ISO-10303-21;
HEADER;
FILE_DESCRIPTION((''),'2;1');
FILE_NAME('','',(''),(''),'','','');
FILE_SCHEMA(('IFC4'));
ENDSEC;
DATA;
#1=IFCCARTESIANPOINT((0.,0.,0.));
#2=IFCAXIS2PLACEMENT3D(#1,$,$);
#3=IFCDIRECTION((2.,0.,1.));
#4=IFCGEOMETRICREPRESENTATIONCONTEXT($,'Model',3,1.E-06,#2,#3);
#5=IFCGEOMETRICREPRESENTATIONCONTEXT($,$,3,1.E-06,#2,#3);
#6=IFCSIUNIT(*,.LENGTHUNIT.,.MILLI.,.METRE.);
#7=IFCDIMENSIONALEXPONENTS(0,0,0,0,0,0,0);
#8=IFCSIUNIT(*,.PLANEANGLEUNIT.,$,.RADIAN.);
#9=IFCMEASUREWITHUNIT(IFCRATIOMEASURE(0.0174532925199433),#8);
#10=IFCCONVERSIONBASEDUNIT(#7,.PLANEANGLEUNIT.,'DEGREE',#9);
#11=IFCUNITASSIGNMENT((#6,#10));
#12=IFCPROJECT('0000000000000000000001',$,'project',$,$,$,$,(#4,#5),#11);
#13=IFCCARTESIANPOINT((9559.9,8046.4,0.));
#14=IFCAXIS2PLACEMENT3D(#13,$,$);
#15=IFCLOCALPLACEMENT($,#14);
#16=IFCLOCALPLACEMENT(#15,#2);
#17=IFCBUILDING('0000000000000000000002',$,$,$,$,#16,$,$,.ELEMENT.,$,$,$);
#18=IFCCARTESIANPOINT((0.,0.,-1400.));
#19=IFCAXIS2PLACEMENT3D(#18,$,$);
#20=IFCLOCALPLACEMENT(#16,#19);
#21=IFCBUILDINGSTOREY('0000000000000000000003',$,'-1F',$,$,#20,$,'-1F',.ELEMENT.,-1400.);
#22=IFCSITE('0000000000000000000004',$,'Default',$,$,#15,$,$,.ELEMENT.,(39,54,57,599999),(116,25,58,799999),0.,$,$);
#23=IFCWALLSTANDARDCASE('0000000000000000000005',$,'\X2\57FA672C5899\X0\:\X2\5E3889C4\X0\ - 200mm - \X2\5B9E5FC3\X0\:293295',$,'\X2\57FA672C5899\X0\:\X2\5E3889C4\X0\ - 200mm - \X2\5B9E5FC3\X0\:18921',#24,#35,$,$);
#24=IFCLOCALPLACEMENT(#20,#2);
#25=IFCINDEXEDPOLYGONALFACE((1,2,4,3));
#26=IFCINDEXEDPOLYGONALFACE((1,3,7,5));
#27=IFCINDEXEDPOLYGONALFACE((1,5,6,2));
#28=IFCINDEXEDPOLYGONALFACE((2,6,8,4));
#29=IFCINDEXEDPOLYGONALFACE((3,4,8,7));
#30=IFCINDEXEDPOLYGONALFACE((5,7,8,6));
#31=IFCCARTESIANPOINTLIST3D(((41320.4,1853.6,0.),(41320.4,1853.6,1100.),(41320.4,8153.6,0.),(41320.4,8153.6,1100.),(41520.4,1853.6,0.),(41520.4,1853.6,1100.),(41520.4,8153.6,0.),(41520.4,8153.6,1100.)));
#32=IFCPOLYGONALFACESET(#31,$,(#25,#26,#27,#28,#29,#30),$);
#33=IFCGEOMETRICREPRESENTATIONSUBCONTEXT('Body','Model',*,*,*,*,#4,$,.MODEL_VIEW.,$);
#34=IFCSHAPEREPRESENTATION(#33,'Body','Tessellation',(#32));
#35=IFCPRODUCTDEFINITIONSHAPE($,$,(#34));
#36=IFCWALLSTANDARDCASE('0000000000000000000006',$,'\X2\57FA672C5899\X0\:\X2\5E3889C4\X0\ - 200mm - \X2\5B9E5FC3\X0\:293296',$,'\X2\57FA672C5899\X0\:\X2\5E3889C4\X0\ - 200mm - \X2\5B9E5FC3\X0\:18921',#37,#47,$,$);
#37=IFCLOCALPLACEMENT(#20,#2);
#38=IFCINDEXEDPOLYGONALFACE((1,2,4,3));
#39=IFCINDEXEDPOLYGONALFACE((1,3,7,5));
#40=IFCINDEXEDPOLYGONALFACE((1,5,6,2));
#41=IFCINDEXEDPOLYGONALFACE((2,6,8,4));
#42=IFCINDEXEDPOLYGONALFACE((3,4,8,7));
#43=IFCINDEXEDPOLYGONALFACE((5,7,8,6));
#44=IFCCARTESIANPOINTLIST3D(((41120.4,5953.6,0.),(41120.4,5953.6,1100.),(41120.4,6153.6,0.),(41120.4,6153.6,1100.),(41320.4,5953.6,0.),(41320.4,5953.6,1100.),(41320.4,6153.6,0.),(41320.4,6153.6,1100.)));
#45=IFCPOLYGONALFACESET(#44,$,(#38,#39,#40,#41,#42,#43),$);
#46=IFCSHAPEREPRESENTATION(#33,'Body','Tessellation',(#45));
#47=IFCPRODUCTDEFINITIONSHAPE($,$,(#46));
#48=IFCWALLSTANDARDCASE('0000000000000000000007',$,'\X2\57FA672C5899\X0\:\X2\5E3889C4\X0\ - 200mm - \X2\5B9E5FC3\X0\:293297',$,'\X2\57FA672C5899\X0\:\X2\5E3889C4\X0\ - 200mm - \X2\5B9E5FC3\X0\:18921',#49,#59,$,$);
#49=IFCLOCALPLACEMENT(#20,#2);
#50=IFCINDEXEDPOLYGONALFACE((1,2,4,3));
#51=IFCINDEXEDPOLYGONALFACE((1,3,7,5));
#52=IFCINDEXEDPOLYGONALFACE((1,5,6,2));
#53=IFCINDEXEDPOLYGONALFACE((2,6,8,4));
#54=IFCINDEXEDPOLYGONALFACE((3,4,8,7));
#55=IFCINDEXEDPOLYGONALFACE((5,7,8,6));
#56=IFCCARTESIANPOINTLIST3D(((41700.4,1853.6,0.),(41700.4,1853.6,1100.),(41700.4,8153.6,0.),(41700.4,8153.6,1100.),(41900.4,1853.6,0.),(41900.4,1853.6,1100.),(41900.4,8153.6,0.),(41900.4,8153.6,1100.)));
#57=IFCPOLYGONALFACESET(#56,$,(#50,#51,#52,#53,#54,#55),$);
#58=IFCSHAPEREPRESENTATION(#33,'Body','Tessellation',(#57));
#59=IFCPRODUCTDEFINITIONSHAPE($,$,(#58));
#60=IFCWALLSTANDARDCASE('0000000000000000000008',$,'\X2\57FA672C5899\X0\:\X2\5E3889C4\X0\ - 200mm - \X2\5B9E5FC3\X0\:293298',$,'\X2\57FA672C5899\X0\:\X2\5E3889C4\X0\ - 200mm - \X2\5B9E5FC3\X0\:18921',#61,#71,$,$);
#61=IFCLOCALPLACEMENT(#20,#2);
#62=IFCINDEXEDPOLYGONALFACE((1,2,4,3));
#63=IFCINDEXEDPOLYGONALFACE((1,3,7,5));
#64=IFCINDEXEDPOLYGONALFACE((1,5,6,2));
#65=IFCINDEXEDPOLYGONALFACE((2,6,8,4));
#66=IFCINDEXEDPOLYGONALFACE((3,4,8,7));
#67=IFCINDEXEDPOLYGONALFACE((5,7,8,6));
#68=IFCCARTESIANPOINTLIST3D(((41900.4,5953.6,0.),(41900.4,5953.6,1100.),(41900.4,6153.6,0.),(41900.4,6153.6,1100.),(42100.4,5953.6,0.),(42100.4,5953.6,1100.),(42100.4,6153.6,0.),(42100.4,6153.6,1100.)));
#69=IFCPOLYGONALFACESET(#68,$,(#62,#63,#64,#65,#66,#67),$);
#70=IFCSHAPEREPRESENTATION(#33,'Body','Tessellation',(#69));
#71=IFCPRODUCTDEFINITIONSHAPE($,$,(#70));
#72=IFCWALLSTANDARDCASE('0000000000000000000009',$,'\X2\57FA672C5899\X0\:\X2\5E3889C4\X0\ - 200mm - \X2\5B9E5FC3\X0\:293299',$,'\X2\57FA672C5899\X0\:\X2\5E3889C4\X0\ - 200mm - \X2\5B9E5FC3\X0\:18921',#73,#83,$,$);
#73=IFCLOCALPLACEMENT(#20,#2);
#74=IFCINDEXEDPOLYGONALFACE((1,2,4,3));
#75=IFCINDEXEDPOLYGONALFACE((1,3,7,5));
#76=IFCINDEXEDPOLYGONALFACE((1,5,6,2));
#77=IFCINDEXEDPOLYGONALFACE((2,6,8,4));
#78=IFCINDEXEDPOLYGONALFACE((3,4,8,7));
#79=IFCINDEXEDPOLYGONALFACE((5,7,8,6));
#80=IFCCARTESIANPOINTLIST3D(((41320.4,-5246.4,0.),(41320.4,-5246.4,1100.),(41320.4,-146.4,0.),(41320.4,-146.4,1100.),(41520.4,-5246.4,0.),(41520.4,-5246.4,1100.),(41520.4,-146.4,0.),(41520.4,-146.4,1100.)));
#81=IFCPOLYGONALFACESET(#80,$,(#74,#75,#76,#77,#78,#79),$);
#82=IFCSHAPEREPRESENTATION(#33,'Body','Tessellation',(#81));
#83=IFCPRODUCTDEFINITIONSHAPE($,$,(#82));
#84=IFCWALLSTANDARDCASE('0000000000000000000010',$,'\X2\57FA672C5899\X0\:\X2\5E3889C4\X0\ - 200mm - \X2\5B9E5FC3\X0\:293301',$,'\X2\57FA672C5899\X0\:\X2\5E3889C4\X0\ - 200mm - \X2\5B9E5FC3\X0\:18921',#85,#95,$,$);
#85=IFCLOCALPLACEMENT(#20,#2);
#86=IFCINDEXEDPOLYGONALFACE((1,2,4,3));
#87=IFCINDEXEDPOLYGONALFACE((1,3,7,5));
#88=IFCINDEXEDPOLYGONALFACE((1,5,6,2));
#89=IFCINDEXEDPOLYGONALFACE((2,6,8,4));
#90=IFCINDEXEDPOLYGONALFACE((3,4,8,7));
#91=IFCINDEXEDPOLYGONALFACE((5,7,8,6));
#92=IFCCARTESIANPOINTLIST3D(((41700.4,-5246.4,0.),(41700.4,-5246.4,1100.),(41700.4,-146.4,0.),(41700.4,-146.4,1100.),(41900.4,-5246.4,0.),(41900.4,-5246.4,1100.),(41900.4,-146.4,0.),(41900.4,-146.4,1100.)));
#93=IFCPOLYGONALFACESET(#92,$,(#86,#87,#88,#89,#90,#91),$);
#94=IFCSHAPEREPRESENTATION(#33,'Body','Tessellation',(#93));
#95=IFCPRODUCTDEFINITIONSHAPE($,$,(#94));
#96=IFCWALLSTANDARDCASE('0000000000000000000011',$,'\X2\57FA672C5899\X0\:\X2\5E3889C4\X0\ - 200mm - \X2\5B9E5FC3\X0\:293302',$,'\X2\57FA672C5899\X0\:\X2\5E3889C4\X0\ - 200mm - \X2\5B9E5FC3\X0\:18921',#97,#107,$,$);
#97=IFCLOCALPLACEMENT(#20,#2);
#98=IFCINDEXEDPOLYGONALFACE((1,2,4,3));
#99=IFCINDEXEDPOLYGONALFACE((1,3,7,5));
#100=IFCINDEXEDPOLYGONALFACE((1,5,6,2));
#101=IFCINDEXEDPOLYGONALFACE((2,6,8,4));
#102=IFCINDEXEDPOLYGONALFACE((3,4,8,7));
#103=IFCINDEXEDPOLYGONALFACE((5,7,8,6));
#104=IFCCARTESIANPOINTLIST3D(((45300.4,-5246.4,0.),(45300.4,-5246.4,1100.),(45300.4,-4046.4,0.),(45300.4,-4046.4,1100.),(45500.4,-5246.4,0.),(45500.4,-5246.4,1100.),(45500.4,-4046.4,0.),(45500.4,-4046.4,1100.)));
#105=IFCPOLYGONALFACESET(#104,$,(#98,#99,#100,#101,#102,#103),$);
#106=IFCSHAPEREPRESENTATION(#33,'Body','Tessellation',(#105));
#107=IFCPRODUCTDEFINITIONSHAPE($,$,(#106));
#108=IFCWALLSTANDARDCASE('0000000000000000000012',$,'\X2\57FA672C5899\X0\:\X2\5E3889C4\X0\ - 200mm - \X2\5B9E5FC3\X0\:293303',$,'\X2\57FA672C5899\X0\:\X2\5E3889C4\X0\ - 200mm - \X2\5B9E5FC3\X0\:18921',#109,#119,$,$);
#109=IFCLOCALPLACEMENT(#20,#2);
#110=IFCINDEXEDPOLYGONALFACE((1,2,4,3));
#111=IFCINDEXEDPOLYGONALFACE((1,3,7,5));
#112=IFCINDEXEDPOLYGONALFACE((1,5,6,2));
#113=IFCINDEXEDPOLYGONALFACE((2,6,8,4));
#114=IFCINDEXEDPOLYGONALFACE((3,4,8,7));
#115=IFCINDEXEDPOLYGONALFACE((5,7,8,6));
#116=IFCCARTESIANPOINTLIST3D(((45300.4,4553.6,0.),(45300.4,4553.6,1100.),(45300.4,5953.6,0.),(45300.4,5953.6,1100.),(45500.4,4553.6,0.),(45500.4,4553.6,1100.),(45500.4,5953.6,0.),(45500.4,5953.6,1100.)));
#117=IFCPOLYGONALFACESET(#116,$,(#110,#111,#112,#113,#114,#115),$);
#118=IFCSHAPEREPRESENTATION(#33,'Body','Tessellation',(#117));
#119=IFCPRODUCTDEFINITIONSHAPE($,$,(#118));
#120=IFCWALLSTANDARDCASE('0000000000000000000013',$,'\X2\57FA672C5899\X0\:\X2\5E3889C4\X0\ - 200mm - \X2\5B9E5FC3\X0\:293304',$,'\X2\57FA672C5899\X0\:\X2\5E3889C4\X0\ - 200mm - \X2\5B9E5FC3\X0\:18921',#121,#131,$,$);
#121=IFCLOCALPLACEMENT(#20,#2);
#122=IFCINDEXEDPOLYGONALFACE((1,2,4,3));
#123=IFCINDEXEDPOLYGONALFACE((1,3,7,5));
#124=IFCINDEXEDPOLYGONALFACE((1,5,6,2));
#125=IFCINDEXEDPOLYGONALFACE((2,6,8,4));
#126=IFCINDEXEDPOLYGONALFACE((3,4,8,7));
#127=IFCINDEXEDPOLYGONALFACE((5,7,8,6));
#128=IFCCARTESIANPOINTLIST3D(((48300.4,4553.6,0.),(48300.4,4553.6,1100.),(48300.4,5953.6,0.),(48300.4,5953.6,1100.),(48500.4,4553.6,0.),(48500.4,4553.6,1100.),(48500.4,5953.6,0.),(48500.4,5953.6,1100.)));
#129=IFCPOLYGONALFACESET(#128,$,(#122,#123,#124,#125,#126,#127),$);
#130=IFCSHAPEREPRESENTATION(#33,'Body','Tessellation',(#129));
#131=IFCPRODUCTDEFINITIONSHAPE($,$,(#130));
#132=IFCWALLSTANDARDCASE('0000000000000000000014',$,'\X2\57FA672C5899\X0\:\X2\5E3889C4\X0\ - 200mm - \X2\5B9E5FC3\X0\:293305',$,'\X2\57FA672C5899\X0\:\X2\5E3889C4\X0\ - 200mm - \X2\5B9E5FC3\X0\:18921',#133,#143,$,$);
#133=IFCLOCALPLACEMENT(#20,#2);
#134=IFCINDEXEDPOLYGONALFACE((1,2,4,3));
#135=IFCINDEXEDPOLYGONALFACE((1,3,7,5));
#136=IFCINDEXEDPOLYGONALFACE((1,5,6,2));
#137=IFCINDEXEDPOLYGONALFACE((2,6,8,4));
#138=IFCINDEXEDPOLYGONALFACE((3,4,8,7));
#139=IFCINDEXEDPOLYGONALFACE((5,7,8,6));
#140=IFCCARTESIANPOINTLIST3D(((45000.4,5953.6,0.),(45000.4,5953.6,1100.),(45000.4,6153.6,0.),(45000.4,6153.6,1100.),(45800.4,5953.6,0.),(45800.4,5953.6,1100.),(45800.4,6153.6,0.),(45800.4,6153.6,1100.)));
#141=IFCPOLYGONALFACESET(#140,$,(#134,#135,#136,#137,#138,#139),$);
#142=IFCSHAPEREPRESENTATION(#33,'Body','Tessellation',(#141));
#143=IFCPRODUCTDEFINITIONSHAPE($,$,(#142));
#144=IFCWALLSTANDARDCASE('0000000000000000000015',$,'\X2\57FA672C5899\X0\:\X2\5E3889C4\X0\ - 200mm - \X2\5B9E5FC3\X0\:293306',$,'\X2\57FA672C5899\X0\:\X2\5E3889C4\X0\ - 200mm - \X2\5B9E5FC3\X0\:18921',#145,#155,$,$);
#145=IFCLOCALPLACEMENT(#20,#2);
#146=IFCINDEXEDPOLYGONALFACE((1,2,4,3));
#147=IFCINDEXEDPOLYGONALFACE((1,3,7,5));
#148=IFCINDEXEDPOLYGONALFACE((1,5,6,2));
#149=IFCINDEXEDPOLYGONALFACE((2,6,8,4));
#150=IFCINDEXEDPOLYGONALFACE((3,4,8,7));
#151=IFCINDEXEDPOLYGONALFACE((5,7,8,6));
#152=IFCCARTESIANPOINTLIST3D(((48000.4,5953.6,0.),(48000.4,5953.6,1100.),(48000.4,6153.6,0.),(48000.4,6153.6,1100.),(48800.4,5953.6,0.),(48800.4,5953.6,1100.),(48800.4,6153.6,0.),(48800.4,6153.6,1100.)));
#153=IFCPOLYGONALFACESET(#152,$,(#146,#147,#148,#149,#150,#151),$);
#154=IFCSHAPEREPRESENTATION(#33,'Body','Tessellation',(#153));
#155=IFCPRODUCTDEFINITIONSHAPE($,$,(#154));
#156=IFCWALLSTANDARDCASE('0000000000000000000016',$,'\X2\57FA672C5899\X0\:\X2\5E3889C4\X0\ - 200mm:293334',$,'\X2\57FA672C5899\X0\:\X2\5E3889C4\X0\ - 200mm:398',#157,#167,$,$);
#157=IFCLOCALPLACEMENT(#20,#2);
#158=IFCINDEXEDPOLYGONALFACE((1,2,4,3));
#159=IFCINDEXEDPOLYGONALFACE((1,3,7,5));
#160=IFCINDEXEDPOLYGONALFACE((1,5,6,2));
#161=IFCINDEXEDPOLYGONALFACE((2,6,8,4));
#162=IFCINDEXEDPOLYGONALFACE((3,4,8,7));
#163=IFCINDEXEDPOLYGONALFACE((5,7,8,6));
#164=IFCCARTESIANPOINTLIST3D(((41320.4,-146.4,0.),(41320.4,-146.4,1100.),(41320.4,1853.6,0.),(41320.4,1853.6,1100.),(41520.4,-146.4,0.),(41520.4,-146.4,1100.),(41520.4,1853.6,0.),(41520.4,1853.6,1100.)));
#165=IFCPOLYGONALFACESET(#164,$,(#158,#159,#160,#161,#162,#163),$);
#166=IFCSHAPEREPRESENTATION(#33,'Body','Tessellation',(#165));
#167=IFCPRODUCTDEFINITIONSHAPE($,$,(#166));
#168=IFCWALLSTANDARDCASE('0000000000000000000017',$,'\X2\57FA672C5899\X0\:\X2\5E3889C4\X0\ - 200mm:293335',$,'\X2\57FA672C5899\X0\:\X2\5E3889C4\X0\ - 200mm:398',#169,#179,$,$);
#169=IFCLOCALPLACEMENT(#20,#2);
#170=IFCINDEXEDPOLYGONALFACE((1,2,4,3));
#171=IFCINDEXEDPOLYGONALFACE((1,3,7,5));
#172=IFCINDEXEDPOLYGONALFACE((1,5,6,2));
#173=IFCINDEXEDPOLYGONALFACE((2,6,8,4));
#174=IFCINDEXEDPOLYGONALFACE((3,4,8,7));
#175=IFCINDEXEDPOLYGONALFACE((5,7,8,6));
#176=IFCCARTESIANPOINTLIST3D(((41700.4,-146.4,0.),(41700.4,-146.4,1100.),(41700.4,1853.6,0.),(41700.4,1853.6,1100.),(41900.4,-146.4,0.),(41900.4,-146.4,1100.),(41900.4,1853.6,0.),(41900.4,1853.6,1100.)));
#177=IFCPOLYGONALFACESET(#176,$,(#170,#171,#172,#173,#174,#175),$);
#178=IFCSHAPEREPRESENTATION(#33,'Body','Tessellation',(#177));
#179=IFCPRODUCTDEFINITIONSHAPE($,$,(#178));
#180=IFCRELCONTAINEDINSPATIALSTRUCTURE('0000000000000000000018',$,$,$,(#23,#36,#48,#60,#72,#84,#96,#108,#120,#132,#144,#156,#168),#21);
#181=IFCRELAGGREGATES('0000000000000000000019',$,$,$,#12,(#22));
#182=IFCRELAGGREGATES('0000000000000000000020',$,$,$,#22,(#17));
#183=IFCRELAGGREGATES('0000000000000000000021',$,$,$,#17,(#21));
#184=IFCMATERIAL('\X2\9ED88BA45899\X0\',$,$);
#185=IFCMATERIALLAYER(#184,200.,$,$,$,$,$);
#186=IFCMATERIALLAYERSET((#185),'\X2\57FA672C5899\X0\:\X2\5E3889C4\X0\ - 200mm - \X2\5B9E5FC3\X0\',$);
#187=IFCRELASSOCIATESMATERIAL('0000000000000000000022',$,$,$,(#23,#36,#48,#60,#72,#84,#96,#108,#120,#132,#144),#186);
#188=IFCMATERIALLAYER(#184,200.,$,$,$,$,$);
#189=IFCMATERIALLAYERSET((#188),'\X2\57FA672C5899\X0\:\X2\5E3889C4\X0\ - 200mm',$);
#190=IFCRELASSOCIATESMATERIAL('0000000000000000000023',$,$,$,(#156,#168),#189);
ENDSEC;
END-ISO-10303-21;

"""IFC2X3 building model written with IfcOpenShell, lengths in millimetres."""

from ifc_helpers import new_model, entity, si_unit, converted_unit, direction, frame, frame_2d, origin, place, context, subcontext, project, spatial, rectangle, extrude, clip, halfspace, material, layer, layer_set, layer_usage, element, save


model = new_model("IFC2X3")

# Units and contexts
model_context = context("Model", 3, precision=1e-06, world=origin(), true_north=direction((2.0, 0.0, 1.0)))
context_of_model = context(None, 3, precision=1e-06, world=origin(), true_north=direction((2.0, 0.0, 1.0)))
body_context = subcontext(model_context, "Body", "Model", "MODEL_VIEW")
ifc_project = project(units=[si_unit("LENGTHUNIT", "METRE", prefix="MILLI"), converted_unit("PLANEANGLEUNIT", "DEGREE", entity("IfcRatioMeasure", 0.0174532925199433), si_unit("PLANEANGLEUNIT", "RADIAN"), dimensions=[0, 0, 0, 0, 0, 0, 0])], contexts=[model_context, context_of_model])

# Site, building, storey
site_placement = place(None, frame((9559.9, 8046.4, 0.0)))
site = spatial("IfcSite", under=ifc_project, at=site_placement, Name="Default", CompositionType="ELEMENT", RefLatitude=(39, 54, 57, 599999), RefLongitude=(116, 25, 58, 799999), RefElevation=0.0)
building_placement = place(site_placement, origin())
building = spatial("IfcBuilding", under=site, at=building_placement, CompositionType="ELEMENT")
storey_placement = place(building_placement, frame((0.0, 0.0, -1400.0)))
storey = spatial("IfcBuildingStorey", under=building, at=storey_placement, Name="-1F", LongName="-1F", CompositionType="ELEMENT", Elevation=-1400.0)

# Walls
ifc_material = material(Name="默认墙")
ifc_layer_1 = layer(ifc_material, 200.0)
ifc_layer_set_1 = layer_set([ifc_layer_1], Name="基本墙:常规 - 200mm - 实心")
ifc_layer_usage_1 = layer_usage(ifc_layer_set_1, "AXIS2", "NEGATIVE", 100.0)
wall_1_placement = place(storey_placement, frame((41420.4, 8153.6, 0.0), z_axis=(0.0, 0.0, 1.0), x_axis=(0.0, -1.0, 0.0)))
element("IfcWallStandardCase", 1, at=wall_1_placement, inside=storey, material=ifc_layer_usage_1, Name="基本墙:常规 - 200mm - 实心:293295", ObjectType="基本墙:常规 - 200mm - 实心:18921", context=body_context, shape_type="Clipping", body=[
    clip(extrude(rectangle(XDim=6300.0, YDim=200.0, at=frame_2d((3150.0, 0.0), x_axis=(-1.0, 0.0))), origin(), (0.0, 0.0, 1.0), 1100.0), halfspace(origin(), True)),
])
ifc_layer_usage_2 = layer_usage(ifc_layer_set_1, "AXIS2", "NEGATIVE", 100.0)
wall_2_placement = place(storey_placement, frame((41320.4, 6053.6, 0.0), z_axis=(0.0, 0.0, 1.0), x_axis=(-1.0, 0.0, 0.0)))
element("IfcWallStandardCase", 2, at=wall_2_placement, inside=storey, material=ifc_layer_usage_2, Name="基本墙:常规 - 200mm - 实心:293296", ObjectType="基本墙:常规 - 200mm - 实心:18921", context=body_context, shape_type="Clipping", body=[
    clip(extrude(rectangle(XDim=200.0, YDim=200.0, at=frame_2d((100.0, 0.0), x_axis=(-1.0, 0.0))), origin(), (0.0, 0.0, 1.0), 1100.0), halfspace(origin(), True)),
])
ifc_layer_usage_3 = layer_usage(ifc_layer_set_1, "AXIS2", "NEGATIVE", 100.0)
wall_3_placement = place(storey_placement, frame((41800.4, 8153.6, 0.0), z_axis=(0.0, 0.0, 1.0), x_axis=(0.0, -1.0, 0.0)))
element("IfcWallStandardCase", 3, at=wall_3_placement, inside=storey, material=ifc_layer_usage_3, Name="基本墙:常规 - 200mm - 实心:293297", ObjectType="基本墙:常规 - 200mm - 实心:18921", context=body_context, shape_type="Clipping", body=[
    clip(extrude(rectangle(XDim=6300.0, YDim=200.0, at=frame_2d((3150.0, 0.0), x_axis=(-1.0, 0.0))), origin(), (0.0, 0.0, 1.0), 1100.0), halfspace(origin(), True)),
])
ifc_layer_usage_4 = layer_usage(ifc_layer_set_1, "AXIS2", "NEGATIVE", 100.0)
wall_4_placement = place(storey_placement, frame((41900.4, 6053.6, 0.0)))
element("IfcWallStandardCase", 4, at=wall_4_placement, inside=storey, material=ifc_layer_usage_4, Name="基本墙:常规 - 200mm - 实心:293298", ObjectType="基本墙:常规 - 200mm - 实心:18921", context=body_context, shape_type="Clipping", body=[
    clip(extrude(rectangle(XDim=200.0, YDim=200.0, at=frame_2d((100.0, 0.0), x_axis=(-1.0, 0.0))), origin(), (0.0, 0.0, 1.0), 1100.0), halfspace(origin(), True)),
])
ifc_layer_usage_5 = layer_usage(ifc_layer_set_1, "AXIS2", "NEGATIVE", 100.0)
wall_5_placement = place(storey_placement, frame((41420.4, -146.4, 0.0), z_axis=(0.0, 0.0, 1.0), x_axis=(0.0, -1.0, 0.0)))
element("IfcWallStandardCase", 5, at=wall_5_placement, inside=storey, material=ifc_layer_usage_5, Name="基本墙:常规 - 200mm - 实心:293299", ObjectType="基本墙:常规 - 200mm - 实心:18921", context=body_context, shape_type="Clipping", body=[
    clip(extrude(rectangle(XDim=5100.0, YDim=200.0, at=frame_2d((2550.0, 0.0), x_axis=(-1.0, 0.0))), origin(), (0.0, 0.0, 1.0), 1100.0), halfspace(origin(), True)),
])
ifc_layer_usage_6 = layer_usage(ifc_layer_set_1, "AXIS2", "NEGATIVE", 100.0)
wall_6_placement = place(storey_placement, frame((41800.4, -146.4, 0.0), z_axis=(0.0, 0.0, 1.0), x_axis=(0.0, -1.0, 0.0)))
element("IfcWallStandardCase", 6, at=wall_6_placement, inside=storey, material=ifc_layer_usage_6, Name="基本墙:常规 - 200mm - 实心:293301", ObjectType="基本墙:常规 - 200mm - 实心:18921", context=body_context, shape_type="Clipping", body=[
    clip(extrude(rectangle(XDim=5100.0, YDim=200.0, at=frame_2d((2550.0, 0.0), x_axis=(-1.0, 0.0))), origin(), (0.0, 0.0, 1.0), 1100.0), halfspace(origin(), True)),
])
ifc_layer_usage_7 = layer_usage(ifc_layer_set_1, "AXIS2", "NEGATIVE", 100.0)
wall_7_placement = place(storey_placement, frame((45400.4, -5246.4, 0.0), z_axis=(0.0, 0.0, 1.0), x_axis=(0.0, 1.0, 0.0)))
element("IfcWallStandardCase", 7, at=wall_7_placement, inside=storey, material=ifc_layer_usage_7, Name="基本墙:常规 - 200mm - 实心:293302", ObjectType="基本墙:常规 - 200mm - 实心:18921", context=body_context, shape_type="Clipping", body=[
    clip(extrude(rectangle(XDim=1200.0, YDim=200.0, at=frame_2d((600.0, 0.0), x_axis=(-1.0, 0.0))), origin(), (0.0, 0.0, 1.0), 1100.0), halfspace(origin(), True)),
])
ifc_layer_usage_8 = layer_usage(ifc_layer_set_1, "AXIS2", "NEGATIVE", 100.0)
wall_8_placement = place(storey_placement, frame((45400.4, 5953.6, 0.0), z_axis=(0.0, 0.0, 1.0), x_axis=(0.0, -1.0, 0.0)))
element("IfcWallStandardCase", 8, at=wall_8_placement, inside=storey, material=ifc_layer_usage_8, Name="基本墙:常规 - 200mm - 实心:293303", ObjectType="基本墙:常规 - 200mm - 实心:18921", context=body_context, shape_type="Clipping", body=[
    clip(extrude(rectangle(XDim=1400.0, YDim=200.0, at=frame_2d((700.0, 0.0), x_axis=(-1.0, 0.0))), origin(), (0.0, 0.0, 1.0), 1100.0), halfspace(origin(), True)),
])
ifc_layer_usage_9 = layer_usage(ifc_layer_set_1, "AXIS2", "NEGATIVE", 100.0)
wall_9_placement = place(storey_placement, frame((48400.4, 5953.6, 0.0), z_axis=(0.0, 0.0, 1.0), x_axis=(0.0, -1.0, 0.0)))
element("IfcWallStandardCase", 9, at=wall_9_placement, inside=storey, material=ifc_layer_usage_9, Name="基本墙:常规 - 200mm - 实心:293304", ObjectType="基本墙:常规 - 200mm - 实心:18921", context=body_context, shape_type="Clipping", body=[
    clip(extrude(rectangle(XDim=1400.0, YDim=200.0, at=frame_2d((700.0, 0.0), x_axis=(-1.0, 0.0))), origin(), (0.0, 0.0, 1.0), 1100.0), halfspace(origin(), True)),
])
ifc_layer_usage_10 = layer_usage(ifc_layer_set_1, "AXIS2", "NEGATIVE", 100.0)
wall_10_placement = place(storey_placement, frame((45800.4, 6053.6, 0.0), z_axis=(0.0, 0.0, 1.0), x_axis=(-1.0, 0.0, 0.0)))
element("IfcWallStandardCase", 10, at=wall_10_placement, inside=storey, material=ifc_layer_usage_10, Name="基本墙:常规 - 200mm - 实心:293305", ObjectType="基本墙:常规 - 200mm - 实心:18921", context=body_context, shape_type="Clipping", body=[
    clip(extrude(rectangle(XDim=800.0, YDim=200.0, at=frame_2d((400.0, 0.0), x_axis=(-1.0, 0.0))), origin(), (0.0, 0.0, 1.0), 1100.0), halfspace(origin(), True)),
])
ifc_layer_usage_11 = layer_usage(ifc_layer_set_1, "AXIS2", "NEGATIVE", 100.0)
wall_11_placement = place(storey_placement, frame((48800.4, 6053.6, 0.0), z_axis=(0.0, 0.0, 1.0), x_axis=(-1.0, 0.0, 0.0)))
element("IfcWallStandardCase", 11, at=wall_11_placement, inside=storey, material=ifc_layer_usage_11, Name="基本墙:常规 - 200mm - 实心:293306", ObjectType="基本墙:常规 - 200mm - 实心:18921", context=body_context, shape_type="Clipping", body=[
    clip(extrude(rectangle(XDim=800.0, YDim=200.0, at=frame_2d((400.0, 0.0), x_axis=(-1.0, 0.0))), origin(), (0.0, 0.0, 1.0), 1100.0), halfspace(origin(), True)),
])
ifc_layer_2 = layer(ifc_material, 200.0)
ifc_layer_set_2 = layer_set([ifc_layer_2], Name="基本墙:常规 - 200mm")
ifc_layer_usage_12 = layer_usage(ifc_layer_set_2, "AXIS2", "NEGATIVE", 100.0)
wall_12_placement = place(storey_placement, frame((41420.4, 1853.6, 0.0), z_axis=(0.0, 0.0, 1.0), x_axis=(0.0, -1.0, 0.0)))
element("IfcWallStandardCase", 12, at=wall_12_placement, inside=storey, material=ifc_layer_usage_12, Name="基本墙:常规 - 200mm:293334", ObjectType="基本墙:常规 - 200mm:398", context=body_context, shape_type="Clipping", body=[
    clip(extrude(rectangle(XDim=2000.0, YDim=200.0, at=frame_2d((1000.0, 0.0), x_axis=(-1.0, 0.0))), origin(), (0.0, 0.0, 1.0), 1100.0), halfspace(origin(), True)),
])
ifc_layer_usage_13 = layer_usage(ifc_layer_set_2, "AXIS2", "NEGATIVE", 100.0)
wall_13_placement = place(storey_placement, frame((41800.4, 1853.6, 0.0), z_axis=(0.0, 0.0, 1.0), x_axis=(0.0, -1.0, 0.0)))
element("IfcWallStandardCase", 13, at=wall_13_placement, inside=storey, material=ifc_layer_usage_13, Name="基本墙:常规 - 200mm:293335", ObjectType="基本墙:常规 - 200mm:398", context=body_context, shape_type="Clipping", body=[
    clip(extrude(rectangle(XDim=2000.0, YDim=200.0, at=frame_2d((1000.0, 0.0), x_axis=(-1.0, 0.0))), origin(), (0.0, 0.0, 1.0), 1100.0), halfspace(origin(), True)),
])

save(model, "model.ifc")
